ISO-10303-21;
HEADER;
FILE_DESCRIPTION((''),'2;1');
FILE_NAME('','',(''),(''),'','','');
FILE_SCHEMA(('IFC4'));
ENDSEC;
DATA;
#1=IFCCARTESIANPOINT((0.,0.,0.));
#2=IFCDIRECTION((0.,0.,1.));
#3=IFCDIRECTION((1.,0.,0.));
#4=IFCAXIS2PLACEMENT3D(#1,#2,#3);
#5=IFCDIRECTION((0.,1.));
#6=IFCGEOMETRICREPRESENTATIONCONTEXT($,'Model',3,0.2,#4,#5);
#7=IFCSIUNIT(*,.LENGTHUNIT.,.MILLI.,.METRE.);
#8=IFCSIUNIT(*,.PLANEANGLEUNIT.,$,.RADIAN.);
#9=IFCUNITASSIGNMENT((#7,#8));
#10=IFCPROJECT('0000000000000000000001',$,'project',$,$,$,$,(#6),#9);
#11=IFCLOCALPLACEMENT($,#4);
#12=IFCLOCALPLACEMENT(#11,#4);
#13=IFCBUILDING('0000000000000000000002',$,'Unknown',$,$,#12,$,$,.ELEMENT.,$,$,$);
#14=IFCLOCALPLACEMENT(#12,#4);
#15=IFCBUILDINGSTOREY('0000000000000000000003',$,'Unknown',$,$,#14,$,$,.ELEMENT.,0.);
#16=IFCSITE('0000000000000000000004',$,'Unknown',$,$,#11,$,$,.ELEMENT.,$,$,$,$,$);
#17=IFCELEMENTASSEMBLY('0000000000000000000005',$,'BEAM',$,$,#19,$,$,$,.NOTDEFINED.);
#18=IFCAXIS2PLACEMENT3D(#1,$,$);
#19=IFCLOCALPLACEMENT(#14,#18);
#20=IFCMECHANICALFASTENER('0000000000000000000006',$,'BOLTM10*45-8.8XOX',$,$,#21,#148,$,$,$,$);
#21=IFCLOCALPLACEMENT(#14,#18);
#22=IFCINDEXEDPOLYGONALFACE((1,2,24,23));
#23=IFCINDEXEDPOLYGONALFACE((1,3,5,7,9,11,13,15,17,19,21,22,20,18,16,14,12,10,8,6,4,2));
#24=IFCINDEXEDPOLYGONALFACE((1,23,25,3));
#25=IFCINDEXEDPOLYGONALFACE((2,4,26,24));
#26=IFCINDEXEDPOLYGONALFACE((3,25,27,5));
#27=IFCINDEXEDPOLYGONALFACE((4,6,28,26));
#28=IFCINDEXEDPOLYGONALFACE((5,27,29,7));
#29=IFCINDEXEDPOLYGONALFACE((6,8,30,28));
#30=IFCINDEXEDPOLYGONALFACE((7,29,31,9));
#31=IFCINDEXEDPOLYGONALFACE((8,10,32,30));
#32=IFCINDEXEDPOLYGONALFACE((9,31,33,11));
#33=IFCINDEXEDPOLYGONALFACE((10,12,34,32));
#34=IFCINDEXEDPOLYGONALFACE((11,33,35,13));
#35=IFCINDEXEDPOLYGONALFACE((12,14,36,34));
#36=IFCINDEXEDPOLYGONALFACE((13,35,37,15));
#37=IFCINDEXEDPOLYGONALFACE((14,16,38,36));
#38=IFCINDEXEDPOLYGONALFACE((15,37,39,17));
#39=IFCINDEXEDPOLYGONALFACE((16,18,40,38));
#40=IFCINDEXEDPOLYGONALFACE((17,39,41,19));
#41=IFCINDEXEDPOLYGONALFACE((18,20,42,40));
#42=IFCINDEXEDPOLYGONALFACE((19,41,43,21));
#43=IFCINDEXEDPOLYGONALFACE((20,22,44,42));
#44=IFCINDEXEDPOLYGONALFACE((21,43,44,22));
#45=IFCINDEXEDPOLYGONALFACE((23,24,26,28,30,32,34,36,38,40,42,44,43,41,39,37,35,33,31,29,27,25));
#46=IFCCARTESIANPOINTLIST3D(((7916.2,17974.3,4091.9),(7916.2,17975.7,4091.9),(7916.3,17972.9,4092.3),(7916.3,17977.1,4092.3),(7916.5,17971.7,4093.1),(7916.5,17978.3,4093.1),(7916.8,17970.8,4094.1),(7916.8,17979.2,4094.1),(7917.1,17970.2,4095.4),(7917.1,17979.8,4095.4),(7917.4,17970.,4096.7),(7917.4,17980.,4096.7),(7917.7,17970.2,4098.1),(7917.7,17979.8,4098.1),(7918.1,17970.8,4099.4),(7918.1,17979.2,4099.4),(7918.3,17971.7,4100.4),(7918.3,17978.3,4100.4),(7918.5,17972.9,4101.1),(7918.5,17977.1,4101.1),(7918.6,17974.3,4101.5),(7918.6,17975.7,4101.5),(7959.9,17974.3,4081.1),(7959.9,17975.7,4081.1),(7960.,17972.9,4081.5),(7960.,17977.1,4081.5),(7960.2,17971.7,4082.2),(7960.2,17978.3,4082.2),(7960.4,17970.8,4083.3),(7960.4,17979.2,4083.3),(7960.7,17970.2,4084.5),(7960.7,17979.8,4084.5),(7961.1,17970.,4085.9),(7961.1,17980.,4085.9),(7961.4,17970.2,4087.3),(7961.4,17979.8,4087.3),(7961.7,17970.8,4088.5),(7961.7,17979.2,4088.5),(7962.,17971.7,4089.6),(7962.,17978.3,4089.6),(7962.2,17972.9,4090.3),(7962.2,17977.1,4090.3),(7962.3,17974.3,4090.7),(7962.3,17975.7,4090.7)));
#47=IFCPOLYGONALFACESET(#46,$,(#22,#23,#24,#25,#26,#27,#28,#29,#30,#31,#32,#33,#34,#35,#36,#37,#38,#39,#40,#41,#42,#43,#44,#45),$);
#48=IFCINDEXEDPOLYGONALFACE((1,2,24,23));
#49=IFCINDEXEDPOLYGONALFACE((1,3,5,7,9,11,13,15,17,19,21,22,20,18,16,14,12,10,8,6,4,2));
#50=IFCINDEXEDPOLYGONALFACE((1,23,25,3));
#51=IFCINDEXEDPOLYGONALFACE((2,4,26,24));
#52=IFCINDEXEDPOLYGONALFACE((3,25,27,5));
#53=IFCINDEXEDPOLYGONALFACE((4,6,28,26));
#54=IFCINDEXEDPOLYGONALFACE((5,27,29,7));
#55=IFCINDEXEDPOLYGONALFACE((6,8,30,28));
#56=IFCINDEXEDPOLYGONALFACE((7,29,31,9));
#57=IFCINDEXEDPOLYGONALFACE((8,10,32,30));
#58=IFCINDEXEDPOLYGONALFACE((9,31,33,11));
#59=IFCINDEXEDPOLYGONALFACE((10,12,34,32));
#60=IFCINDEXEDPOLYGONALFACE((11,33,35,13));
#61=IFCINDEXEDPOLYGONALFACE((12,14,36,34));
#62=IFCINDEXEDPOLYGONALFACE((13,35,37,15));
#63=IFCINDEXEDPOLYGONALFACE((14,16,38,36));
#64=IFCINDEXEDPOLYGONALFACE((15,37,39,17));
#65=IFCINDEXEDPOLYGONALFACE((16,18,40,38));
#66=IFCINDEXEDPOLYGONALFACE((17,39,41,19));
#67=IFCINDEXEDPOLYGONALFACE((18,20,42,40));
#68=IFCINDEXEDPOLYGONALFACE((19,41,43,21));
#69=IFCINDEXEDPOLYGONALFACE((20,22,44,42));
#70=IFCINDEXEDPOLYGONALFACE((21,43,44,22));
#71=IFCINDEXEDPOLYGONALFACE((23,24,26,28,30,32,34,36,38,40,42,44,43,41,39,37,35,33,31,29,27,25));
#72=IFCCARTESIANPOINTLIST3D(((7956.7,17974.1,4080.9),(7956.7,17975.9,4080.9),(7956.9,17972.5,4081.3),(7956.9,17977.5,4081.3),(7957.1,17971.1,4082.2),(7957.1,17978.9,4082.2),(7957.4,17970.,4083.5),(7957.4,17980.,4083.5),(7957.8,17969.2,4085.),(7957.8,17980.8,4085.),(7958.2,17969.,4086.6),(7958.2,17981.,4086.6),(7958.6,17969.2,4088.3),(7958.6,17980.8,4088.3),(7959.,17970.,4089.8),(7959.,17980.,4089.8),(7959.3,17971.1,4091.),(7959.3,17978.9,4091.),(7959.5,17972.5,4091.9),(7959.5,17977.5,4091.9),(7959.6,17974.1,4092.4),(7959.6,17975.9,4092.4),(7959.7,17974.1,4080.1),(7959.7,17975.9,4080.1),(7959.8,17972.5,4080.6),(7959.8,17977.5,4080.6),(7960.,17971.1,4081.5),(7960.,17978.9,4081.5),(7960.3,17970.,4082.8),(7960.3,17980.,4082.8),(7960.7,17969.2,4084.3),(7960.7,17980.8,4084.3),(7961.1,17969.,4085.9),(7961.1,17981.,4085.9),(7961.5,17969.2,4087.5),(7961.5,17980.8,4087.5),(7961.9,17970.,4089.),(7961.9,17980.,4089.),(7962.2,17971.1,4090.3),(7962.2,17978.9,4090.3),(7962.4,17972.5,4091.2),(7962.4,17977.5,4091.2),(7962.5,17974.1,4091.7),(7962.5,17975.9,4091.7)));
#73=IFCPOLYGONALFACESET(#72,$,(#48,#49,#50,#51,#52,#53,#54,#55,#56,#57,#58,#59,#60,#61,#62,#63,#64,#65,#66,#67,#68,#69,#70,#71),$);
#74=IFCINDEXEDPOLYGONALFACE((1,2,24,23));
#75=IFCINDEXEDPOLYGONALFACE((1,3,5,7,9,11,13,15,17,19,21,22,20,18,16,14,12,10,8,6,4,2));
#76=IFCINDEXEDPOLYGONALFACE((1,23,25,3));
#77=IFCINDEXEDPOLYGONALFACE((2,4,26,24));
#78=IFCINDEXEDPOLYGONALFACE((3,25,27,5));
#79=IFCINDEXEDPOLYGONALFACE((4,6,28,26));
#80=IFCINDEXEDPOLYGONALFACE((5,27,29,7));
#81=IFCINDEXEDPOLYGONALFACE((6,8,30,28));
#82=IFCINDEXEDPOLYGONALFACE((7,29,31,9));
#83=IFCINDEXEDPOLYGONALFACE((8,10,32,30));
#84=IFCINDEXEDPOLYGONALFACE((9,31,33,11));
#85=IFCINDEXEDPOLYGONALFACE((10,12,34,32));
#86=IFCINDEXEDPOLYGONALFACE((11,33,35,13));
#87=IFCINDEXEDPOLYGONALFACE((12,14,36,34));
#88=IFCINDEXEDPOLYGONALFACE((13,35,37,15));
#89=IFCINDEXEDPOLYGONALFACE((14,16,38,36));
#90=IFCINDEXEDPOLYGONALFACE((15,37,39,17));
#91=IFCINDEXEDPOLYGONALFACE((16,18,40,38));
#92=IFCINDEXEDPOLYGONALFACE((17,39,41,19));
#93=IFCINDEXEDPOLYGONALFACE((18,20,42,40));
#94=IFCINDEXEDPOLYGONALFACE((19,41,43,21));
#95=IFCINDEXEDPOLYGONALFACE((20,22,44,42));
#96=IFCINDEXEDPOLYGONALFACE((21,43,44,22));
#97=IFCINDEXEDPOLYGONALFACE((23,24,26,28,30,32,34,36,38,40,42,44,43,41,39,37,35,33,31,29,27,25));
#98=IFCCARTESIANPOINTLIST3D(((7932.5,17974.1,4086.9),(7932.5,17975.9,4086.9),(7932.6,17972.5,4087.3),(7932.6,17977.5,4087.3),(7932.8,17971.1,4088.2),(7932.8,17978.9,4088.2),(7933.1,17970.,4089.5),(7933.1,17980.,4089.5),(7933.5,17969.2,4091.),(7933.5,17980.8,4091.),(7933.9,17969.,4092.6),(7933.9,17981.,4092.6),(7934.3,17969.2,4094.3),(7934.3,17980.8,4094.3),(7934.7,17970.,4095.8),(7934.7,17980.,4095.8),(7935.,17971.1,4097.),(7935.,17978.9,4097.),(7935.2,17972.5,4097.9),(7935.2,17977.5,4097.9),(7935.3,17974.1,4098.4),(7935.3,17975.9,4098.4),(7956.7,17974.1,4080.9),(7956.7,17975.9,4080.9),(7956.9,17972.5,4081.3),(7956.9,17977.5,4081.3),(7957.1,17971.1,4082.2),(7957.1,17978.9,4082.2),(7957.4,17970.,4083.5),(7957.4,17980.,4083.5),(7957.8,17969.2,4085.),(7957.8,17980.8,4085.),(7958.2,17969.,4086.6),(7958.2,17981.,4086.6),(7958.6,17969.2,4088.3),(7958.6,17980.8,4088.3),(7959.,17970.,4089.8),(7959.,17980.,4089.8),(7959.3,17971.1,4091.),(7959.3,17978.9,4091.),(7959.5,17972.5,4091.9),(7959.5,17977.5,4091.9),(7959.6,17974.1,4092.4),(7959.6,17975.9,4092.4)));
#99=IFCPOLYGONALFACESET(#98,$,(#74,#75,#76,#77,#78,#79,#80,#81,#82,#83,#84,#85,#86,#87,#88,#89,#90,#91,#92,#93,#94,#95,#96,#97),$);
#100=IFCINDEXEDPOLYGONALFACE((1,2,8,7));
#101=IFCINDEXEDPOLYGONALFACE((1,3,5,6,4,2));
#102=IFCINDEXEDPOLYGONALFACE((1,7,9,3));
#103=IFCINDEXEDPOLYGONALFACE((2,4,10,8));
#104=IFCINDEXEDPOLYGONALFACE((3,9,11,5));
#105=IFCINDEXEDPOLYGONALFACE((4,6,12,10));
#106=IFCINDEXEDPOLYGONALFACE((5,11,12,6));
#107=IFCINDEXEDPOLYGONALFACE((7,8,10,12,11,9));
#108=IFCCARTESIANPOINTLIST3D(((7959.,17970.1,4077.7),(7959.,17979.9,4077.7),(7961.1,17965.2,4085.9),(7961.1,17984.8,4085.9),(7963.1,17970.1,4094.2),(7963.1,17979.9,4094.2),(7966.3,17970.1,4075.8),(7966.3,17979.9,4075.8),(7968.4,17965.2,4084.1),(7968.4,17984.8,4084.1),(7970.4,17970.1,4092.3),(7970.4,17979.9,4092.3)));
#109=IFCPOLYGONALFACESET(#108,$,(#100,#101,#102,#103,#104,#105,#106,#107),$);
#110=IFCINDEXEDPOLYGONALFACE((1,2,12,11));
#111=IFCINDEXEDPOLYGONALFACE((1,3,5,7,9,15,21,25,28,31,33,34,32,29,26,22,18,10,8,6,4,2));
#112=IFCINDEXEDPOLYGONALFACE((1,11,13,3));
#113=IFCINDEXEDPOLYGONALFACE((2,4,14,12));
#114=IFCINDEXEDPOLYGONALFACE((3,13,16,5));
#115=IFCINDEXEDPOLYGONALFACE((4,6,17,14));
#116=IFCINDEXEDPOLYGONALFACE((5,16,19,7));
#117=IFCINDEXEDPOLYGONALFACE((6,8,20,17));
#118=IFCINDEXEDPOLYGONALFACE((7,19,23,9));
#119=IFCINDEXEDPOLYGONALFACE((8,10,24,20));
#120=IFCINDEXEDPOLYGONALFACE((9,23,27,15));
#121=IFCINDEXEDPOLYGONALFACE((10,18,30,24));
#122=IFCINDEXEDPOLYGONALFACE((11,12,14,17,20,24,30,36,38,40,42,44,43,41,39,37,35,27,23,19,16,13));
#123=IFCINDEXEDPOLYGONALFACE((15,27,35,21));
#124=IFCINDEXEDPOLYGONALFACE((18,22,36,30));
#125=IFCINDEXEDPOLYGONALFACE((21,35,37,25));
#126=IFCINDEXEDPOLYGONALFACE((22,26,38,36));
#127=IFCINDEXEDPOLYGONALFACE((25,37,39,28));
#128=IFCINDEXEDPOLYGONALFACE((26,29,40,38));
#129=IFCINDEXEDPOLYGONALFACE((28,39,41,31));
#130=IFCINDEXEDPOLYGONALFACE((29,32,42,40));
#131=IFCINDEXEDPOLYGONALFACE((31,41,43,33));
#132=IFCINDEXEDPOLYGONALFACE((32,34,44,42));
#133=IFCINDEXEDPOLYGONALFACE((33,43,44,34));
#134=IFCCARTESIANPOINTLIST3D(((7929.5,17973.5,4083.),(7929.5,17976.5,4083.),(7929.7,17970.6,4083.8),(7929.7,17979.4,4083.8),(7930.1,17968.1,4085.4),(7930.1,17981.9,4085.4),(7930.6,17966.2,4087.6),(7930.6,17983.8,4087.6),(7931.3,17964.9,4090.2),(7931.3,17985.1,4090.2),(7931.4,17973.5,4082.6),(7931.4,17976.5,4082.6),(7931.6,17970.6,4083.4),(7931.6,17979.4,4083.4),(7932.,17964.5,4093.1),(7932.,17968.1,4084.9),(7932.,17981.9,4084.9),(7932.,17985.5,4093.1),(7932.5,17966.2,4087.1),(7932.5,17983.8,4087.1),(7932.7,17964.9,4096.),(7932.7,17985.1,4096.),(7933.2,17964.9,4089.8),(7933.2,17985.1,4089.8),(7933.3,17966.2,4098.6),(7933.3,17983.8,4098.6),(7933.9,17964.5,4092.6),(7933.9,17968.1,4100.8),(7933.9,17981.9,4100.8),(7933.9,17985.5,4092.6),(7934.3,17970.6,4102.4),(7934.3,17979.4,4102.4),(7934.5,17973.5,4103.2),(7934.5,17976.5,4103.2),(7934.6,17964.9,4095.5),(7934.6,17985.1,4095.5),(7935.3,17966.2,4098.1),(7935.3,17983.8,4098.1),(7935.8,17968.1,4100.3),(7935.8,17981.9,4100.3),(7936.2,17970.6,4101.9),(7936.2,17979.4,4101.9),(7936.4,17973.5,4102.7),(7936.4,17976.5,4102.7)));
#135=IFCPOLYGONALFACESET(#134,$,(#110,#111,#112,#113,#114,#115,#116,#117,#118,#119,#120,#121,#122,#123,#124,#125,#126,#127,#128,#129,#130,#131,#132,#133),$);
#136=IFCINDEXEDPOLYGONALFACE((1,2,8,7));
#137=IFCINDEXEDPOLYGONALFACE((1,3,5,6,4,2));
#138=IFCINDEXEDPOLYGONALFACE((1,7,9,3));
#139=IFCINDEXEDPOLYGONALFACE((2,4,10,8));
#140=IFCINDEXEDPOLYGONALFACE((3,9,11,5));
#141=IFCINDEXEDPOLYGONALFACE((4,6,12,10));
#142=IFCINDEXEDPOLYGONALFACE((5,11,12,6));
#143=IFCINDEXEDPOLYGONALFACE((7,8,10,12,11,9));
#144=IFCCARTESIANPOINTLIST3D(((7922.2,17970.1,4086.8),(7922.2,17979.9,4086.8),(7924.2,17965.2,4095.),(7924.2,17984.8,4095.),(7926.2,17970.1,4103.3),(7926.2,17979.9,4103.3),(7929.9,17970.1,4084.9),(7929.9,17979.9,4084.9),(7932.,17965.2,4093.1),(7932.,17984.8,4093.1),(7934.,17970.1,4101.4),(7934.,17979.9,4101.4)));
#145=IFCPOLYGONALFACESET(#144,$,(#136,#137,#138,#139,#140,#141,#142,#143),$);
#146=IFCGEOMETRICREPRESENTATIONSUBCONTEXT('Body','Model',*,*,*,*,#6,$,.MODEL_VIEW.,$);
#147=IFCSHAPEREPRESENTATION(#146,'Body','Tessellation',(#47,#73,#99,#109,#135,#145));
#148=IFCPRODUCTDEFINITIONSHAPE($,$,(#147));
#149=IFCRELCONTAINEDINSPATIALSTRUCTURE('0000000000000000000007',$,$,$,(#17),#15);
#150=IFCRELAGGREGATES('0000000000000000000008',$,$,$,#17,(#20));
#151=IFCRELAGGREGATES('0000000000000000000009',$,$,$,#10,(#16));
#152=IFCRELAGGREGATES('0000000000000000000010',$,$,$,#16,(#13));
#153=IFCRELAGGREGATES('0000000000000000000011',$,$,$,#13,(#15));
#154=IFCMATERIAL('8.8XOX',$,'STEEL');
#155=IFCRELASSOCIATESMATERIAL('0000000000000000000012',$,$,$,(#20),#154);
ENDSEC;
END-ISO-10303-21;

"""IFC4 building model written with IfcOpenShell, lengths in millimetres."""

from ifc_helpers import new_model, si_unit, direction, frame, origin_with_axes, place, context, subcontext, project, spatial, line, arc, indexed_curve, outline, extrude, source, transform, mapped, material, element, aggregate, save


model = new_model("IFC4")

# Units and contexts
model_context = context("Model", 3, precision=0.2, world=origin_with_axes(), true_north=direction((0.0, 1.0)))
body_context = subcontext(model_context, "Body", "Model", "MODEL_VIEW")
ifc_project = project(units=[si_unit("LENGTHUNIT", "METRE", prefix="MILLI"), si_unit("PLANEANGLEUNIT", "RADIAN")], contexts=[model_context])

# Site, building, storey
site_placement = place(None, origin_with_axes())
site = spatial("IfcSite", under=ifc_project, at=site_placement, Name="Unknown", CompositionType="ELEMENT")
building_placement = place(site_placement, origin_with_axes())
building = spatial("IfcBuilding", under=site, at=building_placement, Name="Unknown", CompositionType="ELEMENT")
storey_placement = place(building_placement, origin_with_axes())
storey = spatial("IfcBuildingStorey", under=building, at=storey_placement, Name="Unknown", CompositionType="ELEMENT", Elevation=0.0)

# Shared definitions
ifc_material_1 = material(Name="8.8XOX", Category="STEEL")

# Element assembly, mechanical fastener
shared_shape_1 = source(origin_with_axes(), body_context, "Body", "SweptSolid", [
    extrude(outline(indexed_curve([(5.0, 0.0), (0.0, 5.0), (-5.0, 0.0), (0.0, -5.0)], segments=[arc(1, 2, 3), arc(3, 4, 1)])), frame((0.0, 0.0, 3.8), z_axis=(0.0, 0.0, -1.0), x_axis=(0.0, 1.0, 0.0)), (0.0, 0.0, 1.0), 45.0),
    extrude(outline(indexed_curve([(6.0, 0.0), (0.0, 6.0), (-6.0, 0.0), (0.0, -6.0)], segments=[arc(1, 2, 3), arc(3, 4, 1)])), frame((0.0, 0.0, 3.8), z_axis=(0.0, 0.0, -1.0), x_axis=(0.0, 1.0, 0.0)), (0.0, 0.0, 1.0), 3.0),
    extrude(outline(indexed_curve([(6.0, 0.0), (0.0, 6.0), (-6.0, 0.0), (0.0, -6.0)], segments=[arc(1, 2, 3), arc(3, 4, 1)])), frame((0.0, 0.0, 0.8), z_axis=(0.0, 0.0, -1.0), x_axis=(0.0, 1.0, 0.0)), (0.0, 0.0, 1.0), 25.0),
    extrude(outline(indexed_curve([(9.8, 0.0), (4.9, 8.5), (-4.9, 8.5), (-9.8, 0.0), (-4.9, -8.5), (4.9, -8.5)], segments=[line(1, 2, 3, 4, 5, 6, 1)])), frame((0.0, 0.0, 11.2), z_axis=(0.0, 0.0, -1.0), x_axis=(0.0, 1.0, 0.0)), (0.0, 0.0, 1.0), 7.5),
    extrude(outline(indexed_curve([(10.5, 0.0), (0.0, 10.5), (-10.5, 0.0), (0.0, -10.5)], segments=[arc(1, 2, 3), arc(3, 4, 1)])), frame((0.0, 0.0, -24.2), z_axis=(0.0, 0.0, -1.0), x_axis=(0.0, 1.0, 0.0)), (0.0, 0.0, 1.0), 2.0),
    extrude(outline(indexed_curve([(9.8, 0.0), (4.9, 8.5), (-4.9, 8.5), (-9.8, 0.0), (-4.9, -8.5), (4.9, -8.5)], segments=[line(1, 2, 3, 4, 5, 6, 1)])), frame((0.0, 0.0, -26.2), z_axis=(0.0, 0.0, -1.0), x_axis=(0.0, 1.0, 0.0)), (0.0, 0.0, 1.0), 8.0),
])
assembly_1_placement = place(storey_placement, frame((7947.2, 12000.0, 4094.5), z_axis=(0.970613, 0.0, -0.240648), x_axis=(0.0, 1.0, 0.0)))
assembly_1 = element("IfcElementAssembly", 1, at=assembly_1_placement, inside=storey, Name="BEAM", PredefinedType="NOTDEFINED")
mechanical_fastener_1_placement = place(assembly_1_placement, frame((5975.0, -5.0, 11.8), z_axis=(0.0, 0.0, 1.0), x_axis=(0.0, 1.0, 0.0)))
mechanical_fastener_1 = element("IfcMechanicalFastener", 2, at=mechanical_fastener_1_placement, material=ifc_material_1, Name="BOLTM10*45-8.8XOX", context=body_context, shape_type="MappedRepresentation", body=[
    mapped(shared_shape_1, transform((0.0, 0.0, 0.0))),
])
aggregate(assembly_1, [mechanical_fastener_1])

save(model, "model.ifc")
